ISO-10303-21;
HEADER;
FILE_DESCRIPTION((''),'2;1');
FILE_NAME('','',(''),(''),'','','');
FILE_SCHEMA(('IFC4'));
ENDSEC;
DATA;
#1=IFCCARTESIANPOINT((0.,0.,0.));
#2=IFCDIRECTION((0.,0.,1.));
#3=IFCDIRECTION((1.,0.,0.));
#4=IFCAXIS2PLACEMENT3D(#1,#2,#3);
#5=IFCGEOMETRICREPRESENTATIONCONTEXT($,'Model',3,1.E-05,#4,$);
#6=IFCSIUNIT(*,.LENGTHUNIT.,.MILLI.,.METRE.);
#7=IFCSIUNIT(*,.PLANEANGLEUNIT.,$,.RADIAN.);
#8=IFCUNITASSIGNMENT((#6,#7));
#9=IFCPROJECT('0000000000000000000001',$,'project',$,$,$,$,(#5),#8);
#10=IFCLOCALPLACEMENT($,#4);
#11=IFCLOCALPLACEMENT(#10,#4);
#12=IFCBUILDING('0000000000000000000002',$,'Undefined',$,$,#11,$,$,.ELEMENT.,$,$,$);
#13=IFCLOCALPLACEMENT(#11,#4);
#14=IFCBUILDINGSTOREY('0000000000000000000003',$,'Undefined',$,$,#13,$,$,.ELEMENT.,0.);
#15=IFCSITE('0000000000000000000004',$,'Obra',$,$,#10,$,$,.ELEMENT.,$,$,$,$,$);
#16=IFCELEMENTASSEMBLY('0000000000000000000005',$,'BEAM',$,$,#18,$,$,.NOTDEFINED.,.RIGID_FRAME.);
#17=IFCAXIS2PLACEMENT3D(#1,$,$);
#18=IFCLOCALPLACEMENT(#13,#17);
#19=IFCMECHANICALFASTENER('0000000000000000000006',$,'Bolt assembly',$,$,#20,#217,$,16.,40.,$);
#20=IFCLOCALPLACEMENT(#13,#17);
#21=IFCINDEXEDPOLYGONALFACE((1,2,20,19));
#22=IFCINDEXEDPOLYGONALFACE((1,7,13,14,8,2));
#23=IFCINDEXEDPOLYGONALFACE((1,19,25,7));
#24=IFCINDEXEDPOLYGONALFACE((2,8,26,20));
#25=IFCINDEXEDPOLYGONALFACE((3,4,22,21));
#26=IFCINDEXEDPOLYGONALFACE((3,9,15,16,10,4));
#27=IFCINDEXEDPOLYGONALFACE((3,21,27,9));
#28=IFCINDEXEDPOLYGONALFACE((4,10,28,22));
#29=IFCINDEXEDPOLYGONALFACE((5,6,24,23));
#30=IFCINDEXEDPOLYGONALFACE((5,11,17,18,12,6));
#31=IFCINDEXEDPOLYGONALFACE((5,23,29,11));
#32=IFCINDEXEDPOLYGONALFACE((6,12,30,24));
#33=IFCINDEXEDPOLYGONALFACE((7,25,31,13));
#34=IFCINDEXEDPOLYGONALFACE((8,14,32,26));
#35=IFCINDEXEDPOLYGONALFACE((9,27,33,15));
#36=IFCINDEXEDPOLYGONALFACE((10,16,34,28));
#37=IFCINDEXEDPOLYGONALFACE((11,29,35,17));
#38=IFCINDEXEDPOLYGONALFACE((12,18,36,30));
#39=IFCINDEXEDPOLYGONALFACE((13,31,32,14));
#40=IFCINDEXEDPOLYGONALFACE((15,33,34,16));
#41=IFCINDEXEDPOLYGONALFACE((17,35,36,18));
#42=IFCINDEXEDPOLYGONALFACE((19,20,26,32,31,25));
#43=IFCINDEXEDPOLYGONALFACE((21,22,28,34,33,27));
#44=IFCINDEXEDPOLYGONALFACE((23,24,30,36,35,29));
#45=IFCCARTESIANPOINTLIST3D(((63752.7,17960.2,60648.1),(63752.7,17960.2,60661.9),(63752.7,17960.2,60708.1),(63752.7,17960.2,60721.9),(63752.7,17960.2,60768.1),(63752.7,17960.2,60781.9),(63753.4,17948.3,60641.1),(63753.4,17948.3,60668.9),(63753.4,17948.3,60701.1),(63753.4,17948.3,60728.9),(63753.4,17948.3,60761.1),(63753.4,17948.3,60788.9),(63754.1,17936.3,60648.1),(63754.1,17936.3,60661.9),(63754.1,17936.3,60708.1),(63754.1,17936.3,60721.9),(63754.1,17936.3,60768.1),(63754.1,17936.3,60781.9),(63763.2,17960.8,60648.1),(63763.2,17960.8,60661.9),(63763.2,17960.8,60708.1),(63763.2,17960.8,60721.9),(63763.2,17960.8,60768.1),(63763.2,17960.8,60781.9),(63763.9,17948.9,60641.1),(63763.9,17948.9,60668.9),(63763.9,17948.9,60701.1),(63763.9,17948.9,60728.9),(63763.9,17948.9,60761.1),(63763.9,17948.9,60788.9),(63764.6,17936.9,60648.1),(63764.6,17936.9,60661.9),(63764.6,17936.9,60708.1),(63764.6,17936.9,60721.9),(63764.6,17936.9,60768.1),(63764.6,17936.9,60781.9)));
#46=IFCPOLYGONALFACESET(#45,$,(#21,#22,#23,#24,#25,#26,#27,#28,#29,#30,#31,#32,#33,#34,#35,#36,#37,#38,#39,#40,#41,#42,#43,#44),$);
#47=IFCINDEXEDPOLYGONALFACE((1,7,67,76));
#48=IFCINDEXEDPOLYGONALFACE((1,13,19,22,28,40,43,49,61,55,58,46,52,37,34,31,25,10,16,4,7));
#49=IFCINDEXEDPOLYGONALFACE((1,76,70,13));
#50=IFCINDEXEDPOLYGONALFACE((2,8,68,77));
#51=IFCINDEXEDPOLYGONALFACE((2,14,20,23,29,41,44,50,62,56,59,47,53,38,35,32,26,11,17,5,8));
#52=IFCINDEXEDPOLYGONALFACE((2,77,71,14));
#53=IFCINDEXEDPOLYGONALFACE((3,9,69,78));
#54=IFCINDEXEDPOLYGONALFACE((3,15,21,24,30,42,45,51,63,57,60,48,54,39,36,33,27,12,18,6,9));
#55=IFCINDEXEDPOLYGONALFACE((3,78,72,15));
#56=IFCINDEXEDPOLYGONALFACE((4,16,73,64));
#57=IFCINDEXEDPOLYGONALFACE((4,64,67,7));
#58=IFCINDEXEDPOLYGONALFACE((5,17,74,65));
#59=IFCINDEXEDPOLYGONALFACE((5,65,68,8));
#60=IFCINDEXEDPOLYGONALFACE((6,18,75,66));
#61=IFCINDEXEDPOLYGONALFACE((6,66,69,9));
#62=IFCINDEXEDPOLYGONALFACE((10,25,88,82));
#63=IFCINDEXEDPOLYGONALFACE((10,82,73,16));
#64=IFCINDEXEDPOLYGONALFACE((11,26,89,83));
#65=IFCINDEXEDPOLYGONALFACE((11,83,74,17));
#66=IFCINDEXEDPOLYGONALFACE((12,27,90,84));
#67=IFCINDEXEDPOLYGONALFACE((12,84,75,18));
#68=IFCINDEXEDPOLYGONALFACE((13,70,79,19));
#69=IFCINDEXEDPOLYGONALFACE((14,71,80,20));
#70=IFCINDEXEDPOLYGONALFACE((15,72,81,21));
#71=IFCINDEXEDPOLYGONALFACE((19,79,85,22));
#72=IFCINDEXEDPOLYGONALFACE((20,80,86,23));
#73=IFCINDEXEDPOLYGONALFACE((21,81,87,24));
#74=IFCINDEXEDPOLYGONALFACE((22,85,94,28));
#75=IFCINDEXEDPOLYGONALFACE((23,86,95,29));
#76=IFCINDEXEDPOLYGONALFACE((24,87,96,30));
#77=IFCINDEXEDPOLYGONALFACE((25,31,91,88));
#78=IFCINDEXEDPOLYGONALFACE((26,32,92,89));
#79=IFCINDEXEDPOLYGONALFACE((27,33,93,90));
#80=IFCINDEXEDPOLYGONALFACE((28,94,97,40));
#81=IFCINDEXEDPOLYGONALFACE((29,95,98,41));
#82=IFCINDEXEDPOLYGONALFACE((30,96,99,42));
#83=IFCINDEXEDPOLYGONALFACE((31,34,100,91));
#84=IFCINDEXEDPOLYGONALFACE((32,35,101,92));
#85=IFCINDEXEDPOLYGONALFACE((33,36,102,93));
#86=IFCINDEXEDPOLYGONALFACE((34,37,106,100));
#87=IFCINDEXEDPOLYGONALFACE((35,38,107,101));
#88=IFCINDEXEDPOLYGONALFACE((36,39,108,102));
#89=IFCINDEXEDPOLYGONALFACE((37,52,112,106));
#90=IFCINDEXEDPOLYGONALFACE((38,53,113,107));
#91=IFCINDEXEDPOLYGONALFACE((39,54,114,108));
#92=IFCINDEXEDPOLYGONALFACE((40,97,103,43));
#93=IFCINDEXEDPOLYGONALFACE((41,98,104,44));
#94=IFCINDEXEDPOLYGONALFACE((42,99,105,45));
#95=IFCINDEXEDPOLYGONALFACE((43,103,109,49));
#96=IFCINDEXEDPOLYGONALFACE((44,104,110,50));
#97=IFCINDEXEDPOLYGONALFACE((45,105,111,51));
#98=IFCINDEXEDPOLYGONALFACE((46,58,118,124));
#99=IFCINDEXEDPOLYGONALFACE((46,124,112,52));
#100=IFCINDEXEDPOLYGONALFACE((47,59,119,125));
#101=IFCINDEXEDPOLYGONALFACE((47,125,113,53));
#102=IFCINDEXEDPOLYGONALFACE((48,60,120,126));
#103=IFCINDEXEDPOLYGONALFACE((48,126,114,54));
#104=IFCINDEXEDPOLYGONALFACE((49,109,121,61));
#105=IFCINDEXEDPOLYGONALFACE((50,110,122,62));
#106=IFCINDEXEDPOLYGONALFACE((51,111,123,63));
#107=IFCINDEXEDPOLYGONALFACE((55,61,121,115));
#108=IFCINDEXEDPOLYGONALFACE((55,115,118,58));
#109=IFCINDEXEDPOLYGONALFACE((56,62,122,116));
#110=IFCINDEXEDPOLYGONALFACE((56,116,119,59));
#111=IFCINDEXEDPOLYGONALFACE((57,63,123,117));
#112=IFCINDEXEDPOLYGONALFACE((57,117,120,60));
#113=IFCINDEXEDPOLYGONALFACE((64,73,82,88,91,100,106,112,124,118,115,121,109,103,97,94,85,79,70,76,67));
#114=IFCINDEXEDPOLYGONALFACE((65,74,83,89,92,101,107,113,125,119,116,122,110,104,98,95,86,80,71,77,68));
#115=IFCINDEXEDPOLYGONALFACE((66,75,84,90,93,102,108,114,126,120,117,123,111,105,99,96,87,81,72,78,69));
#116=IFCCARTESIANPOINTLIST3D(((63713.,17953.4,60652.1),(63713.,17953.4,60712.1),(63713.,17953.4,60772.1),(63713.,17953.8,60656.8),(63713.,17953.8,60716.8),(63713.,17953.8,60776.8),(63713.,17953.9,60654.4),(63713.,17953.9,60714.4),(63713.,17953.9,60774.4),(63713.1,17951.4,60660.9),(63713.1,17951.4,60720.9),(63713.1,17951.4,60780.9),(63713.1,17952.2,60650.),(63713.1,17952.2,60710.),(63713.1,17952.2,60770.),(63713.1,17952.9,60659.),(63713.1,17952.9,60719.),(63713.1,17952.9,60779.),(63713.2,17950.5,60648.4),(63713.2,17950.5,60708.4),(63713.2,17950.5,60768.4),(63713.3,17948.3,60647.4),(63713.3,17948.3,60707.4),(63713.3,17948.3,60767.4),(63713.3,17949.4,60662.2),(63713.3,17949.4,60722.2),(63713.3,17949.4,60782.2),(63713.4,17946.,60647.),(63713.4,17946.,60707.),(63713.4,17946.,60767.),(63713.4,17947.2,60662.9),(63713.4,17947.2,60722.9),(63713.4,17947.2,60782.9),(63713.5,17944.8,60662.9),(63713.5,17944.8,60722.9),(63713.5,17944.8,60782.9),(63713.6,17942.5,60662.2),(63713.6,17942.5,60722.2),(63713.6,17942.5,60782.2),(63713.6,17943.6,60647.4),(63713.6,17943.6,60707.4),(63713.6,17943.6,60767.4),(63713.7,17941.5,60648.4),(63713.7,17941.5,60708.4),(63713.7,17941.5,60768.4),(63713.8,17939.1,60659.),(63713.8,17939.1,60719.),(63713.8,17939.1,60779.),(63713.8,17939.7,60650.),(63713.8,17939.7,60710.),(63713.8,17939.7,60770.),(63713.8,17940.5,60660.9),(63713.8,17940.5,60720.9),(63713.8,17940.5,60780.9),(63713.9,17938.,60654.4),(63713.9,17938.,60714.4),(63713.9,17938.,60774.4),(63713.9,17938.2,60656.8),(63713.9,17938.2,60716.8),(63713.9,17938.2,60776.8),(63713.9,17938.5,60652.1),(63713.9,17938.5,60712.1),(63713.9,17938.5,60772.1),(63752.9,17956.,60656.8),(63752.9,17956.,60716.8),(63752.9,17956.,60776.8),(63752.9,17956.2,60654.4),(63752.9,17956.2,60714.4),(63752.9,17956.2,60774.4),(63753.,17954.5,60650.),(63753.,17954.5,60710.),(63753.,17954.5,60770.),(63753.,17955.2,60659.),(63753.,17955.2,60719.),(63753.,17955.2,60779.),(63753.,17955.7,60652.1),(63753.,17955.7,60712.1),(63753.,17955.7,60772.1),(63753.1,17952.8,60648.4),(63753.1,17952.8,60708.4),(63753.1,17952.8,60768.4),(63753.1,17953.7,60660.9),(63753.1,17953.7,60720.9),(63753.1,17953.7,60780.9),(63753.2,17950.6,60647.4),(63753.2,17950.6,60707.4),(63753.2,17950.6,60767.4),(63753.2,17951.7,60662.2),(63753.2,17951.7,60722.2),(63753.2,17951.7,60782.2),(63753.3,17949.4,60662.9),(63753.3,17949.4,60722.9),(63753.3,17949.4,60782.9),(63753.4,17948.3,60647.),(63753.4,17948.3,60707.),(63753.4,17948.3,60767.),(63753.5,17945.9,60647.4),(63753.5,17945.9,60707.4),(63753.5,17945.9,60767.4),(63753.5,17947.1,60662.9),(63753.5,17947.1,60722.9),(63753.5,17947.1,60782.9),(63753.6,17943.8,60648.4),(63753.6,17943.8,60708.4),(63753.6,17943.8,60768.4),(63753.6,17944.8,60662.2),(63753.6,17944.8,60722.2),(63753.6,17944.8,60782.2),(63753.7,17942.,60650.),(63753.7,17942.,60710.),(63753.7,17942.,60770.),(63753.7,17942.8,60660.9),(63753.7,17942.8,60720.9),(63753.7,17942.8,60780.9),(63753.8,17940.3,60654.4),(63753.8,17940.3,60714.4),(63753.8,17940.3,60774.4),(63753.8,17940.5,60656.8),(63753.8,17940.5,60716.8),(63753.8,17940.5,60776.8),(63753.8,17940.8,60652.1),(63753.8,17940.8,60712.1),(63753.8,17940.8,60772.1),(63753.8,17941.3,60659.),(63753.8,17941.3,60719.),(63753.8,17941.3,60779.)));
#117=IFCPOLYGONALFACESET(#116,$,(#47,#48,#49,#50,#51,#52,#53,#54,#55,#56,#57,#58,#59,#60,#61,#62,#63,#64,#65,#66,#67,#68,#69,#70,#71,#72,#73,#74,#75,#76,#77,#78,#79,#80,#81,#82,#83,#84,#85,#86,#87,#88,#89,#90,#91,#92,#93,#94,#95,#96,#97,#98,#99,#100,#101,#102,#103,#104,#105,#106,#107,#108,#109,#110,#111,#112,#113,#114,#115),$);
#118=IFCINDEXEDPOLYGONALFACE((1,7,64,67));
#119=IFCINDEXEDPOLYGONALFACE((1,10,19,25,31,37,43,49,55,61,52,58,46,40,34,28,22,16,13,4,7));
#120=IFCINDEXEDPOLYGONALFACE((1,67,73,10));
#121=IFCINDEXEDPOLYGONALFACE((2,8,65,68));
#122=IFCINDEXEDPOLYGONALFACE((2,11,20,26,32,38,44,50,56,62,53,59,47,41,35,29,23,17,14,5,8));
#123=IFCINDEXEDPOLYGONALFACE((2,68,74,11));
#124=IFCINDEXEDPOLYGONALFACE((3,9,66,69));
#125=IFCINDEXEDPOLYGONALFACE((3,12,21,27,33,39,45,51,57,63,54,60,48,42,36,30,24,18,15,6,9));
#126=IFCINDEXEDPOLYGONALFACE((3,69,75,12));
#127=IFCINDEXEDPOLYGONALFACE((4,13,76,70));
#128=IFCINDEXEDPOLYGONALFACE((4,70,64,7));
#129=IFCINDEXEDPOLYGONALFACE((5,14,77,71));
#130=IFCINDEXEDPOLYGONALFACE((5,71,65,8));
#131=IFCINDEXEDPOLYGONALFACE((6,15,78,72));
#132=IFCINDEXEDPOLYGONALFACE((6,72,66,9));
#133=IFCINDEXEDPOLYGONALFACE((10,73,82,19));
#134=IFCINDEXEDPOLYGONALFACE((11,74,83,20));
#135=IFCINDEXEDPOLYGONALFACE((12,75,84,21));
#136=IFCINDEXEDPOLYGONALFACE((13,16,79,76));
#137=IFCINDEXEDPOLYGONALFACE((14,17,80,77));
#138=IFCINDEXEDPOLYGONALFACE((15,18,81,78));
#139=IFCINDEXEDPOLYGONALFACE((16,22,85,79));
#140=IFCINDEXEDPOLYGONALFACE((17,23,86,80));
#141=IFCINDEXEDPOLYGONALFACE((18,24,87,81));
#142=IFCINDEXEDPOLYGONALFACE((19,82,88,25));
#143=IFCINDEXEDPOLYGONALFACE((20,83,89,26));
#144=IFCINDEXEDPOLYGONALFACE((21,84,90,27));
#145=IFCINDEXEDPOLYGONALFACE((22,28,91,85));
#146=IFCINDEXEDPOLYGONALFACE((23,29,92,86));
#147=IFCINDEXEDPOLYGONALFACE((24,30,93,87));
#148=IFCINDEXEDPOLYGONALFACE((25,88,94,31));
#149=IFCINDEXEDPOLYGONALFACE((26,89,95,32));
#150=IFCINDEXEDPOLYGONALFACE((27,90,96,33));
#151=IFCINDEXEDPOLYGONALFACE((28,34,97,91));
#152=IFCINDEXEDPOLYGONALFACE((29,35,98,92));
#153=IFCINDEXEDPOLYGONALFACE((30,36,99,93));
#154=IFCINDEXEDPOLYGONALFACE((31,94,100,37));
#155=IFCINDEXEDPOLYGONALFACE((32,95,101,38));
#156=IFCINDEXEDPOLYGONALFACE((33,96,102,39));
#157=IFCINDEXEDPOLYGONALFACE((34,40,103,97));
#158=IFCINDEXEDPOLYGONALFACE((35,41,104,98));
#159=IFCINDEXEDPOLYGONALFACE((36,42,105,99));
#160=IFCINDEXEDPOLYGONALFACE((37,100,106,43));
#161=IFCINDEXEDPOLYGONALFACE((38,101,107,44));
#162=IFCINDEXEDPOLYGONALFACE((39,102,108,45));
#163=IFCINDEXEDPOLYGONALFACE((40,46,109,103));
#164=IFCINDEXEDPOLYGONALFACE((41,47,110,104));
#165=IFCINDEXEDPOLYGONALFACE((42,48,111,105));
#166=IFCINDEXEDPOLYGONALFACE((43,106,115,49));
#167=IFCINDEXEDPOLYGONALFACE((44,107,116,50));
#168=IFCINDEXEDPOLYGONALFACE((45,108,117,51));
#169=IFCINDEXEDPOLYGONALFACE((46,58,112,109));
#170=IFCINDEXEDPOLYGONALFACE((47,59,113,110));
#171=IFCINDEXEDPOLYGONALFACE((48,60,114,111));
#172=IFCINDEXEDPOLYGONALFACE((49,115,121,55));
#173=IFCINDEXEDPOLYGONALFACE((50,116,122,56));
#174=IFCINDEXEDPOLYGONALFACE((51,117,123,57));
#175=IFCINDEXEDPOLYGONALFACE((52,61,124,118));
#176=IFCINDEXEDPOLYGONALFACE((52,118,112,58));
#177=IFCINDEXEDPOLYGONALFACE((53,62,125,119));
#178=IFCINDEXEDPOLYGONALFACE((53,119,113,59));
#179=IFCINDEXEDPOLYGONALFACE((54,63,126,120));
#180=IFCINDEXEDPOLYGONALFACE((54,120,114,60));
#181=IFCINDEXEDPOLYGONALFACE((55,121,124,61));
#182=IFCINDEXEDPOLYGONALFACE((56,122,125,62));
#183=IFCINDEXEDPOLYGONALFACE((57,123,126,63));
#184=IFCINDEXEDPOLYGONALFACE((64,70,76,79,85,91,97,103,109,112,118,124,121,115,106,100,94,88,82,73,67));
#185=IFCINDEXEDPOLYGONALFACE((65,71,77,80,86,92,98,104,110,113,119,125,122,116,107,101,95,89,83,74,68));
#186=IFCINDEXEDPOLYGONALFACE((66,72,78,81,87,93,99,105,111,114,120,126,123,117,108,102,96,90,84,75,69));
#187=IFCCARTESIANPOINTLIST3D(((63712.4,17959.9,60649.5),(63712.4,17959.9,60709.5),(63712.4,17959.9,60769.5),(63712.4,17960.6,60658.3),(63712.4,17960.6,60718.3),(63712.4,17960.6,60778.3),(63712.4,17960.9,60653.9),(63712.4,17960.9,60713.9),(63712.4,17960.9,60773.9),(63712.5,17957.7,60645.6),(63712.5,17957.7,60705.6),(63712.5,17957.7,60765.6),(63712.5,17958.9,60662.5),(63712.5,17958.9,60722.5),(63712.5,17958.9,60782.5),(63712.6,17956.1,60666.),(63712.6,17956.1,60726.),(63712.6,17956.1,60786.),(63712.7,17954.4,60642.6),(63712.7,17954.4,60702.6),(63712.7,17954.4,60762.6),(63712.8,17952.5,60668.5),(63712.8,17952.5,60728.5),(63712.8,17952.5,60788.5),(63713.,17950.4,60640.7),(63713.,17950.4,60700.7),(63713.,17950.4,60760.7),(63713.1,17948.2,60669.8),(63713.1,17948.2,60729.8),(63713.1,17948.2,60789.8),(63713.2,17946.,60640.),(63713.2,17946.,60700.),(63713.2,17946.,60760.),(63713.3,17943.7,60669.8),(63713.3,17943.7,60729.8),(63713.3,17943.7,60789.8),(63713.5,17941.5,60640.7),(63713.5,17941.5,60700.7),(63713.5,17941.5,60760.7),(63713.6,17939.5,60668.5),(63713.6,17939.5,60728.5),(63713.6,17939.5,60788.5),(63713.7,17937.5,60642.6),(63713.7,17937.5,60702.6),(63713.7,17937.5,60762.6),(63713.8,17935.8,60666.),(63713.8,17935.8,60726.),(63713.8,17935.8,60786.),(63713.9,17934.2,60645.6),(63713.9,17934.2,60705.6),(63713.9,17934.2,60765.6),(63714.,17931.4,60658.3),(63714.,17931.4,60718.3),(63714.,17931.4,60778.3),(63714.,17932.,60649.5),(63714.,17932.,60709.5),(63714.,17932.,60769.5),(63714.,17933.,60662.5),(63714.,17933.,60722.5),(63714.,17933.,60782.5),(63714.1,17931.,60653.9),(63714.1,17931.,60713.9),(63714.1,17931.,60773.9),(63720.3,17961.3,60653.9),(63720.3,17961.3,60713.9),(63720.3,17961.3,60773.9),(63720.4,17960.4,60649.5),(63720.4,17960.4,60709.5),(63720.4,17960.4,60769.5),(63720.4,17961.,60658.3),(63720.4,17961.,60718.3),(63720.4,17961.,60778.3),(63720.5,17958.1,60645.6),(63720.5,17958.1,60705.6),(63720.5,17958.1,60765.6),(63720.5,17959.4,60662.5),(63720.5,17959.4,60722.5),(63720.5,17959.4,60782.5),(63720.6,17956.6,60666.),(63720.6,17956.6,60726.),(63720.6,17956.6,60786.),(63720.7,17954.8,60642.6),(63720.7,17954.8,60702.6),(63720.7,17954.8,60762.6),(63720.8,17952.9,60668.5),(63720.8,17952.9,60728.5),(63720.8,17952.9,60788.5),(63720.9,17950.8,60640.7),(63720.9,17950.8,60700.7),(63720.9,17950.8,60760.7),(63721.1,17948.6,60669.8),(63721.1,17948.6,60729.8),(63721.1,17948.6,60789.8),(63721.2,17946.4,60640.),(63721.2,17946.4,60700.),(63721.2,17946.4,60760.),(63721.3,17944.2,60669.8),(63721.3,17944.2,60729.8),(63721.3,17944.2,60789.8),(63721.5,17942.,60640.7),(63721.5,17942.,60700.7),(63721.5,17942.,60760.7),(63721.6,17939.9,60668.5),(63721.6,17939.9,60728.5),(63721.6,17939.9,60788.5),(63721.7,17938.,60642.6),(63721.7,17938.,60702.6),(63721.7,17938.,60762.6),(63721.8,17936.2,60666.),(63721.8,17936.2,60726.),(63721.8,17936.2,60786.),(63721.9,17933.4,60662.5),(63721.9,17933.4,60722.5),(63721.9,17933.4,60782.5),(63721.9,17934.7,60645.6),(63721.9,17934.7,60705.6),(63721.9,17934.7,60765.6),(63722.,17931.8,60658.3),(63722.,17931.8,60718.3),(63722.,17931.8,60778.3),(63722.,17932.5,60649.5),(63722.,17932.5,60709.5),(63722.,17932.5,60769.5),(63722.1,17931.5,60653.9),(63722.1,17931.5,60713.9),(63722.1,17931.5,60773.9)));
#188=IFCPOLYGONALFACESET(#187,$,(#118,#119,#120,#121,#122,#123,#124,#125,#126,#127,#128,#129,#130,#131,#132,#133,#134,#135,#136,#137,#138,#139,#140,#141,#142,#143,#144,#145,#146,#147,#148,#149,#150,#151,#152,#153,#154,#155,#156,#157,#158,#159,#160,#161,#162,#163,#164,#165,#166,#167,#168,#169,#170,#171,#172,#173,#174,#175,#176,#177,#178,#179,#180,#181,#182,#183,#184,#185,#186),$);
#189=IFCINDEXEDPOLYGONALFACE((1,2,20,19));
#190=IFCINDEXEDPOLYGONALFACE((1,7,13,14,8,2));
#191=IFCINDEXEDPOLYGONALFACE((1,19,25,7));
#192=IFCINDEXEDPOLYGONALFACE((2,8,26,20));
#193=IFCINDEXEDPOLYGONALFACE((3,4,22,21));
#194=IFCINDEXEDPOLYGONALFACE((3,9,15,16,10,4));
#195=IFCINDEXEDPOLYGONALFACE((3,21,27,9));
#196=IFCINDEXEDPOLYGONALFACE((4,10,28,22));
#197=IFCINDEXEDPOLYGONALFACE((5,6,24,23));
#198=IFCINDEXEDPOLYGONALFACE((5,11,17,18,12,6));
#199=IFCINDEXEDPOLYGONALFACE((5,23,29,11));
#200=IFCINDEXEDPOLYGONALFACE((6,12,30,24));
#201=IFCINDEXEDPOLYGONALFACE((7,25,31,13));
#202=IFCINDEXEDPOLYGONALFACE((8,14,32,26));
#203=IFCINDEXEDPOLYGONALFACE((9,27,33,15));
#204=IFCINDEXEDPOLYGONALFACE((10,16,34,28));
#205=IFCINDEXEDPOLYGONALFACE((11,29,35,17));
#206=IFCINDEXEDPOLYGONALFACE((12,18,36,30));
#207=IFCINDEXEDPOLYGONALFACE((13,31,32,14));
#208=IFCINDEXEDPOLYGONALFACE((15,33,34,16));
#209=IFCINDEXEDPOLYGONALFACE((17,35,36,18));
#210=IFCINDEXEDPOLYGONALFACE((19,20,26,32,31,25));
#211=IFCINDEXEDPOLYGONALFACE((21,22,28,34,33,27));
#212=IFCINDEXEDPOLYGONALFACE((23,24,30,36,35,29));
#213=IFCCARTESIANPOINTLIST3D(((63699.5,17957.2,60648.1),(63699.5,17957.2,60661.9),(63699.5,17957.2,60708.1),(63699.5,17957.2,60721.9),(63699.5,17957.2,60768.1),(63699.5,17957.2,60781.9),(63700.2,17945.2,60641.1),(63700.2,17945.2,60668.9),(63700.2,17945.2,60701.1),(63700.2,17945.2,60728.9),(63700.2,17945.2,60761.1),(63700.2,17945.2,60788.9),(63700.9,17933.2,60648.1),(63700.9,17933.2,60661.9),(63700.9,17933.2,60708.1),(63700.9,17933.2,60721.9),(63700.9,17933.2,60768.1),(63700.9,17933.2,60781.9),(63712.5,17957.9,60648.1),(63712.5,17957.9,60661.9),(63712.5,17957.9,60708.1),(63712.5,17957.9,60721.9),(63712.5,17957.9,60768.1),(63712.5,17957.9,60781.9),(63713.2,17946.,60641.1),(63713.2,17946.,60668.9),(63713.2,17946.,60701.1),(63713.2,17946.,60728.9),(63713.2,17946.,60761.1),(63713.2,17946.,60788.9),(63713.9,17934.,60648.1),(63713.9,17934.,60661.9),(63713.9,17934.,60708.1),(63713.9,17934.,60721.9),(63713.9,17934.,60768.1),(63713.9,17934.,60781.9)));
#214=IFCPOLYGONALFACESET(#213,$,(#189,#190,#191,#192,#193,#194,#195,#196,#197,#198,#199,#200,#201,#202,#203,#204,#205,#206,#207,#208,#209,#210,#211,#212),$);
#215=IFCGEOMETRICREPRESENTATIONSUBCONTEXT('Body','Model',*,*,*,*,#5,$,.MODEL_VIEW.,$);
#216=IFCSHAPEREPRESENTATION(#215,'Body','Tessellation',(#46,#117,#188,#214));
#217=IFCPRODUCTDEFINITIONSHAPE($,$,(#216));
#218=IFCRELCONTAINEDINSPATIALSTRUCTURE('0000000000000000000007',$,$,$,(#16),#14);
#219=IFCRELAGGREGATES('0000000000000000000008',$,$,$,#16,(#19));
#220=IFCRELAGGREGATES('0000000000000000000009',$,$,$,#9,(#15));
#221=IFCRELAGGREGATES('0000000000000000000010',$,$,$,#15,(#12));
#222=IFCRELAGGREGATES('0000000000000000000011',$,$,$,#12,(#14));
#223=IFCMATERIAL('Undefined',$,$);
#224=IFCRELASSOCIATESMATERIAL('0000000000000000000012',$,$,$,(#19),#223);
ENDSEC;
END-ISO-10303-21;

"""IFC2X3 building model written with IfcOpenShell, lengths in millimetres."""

from ifc_helpers import new_model, si_unit, frame, origin_with_axes, origin_2d_with_axis, place, context, subcontext, project, spatial, polyline, circle, outline, extrude, source, transform, mapped, material, element, aggregate, save


model = new_model("IFC2X3")

# Units and contexts
model_context = context("Model", 3, precision=1e-05, world=origin_with_axes())
body_context = subcontext(model_context, "Body", "Model", "MODEL_VIEW")
ifc_project = project(units=[si_unit("LENGTHUNIT", "METRE", prefix="MILLI"), si_unit("PLANEANGLEUNIT", "RADIAN")], contexts=[model_context])

# Site, building, storey
site_placement = place(None, origin_with_axes())
site = spatial("IfcSite", under=ifc_project, at=site_placement, Name="Obra", CompositionType="ELEMENT")
building_placement = place(site_placement, origin_with_axes())
building = spatial("IfcBuilding", under=site, at=building_placement, Name="Undefined", CompositionType="ELEMENT")
storey_placement = place(building_placement, origin_with_axes())
storey = spatial("IfcBuildingStorey", under=building, at=storey_placement, Name="Undefined", CompositionType="ELEMENT", Elevation=0.0)

# Element assembly, mechanical fastener
ifc_material_1 = material(Name="Undefined")
assembly_1_placement = place(storey_placement, origin_with_axes())
assembly_1 = element("IfcElementAssembly", 1, at=assembly_1_placement, inside=storey, Name="BEAM", AssemblyPlace="NOTDEFINED", PredefinedType="RIGID_FRAME")
shared_shape_1 = source(origin_with_axes(), body_context, "Body", "SweptSolid", [
    extrude(outline(polyline([(13.9, 0.0), (6.9, 12.0), (-6.9, 12.0), (-13.9, 0.0), (-6.9, -12.0), (6.9, -12.0), (13.9, 0.0)])), frame((0.0, -45.9, 0.0), z_axis=(0.0, 1.0, 0.0), x_axis=(1.0, 0.0, 0.0)), (0.0, 0.0, 1.0), 10.6),
    extrude(circle(Radius=8.0, at=origin_2d_with_axis()), frame((0.0, -35.3, 0.0), z_axis=(0.0, 1.0, 0.0), x_axis=(1.0, 0.0, 0.0)), (0.0, 0.0, 1.0), 40.0),
    extrude(circle(Radius=15.0, at=origin_2d_with_axis()), frame((0.0, -3.1, 0.0), z_axis=(0.0, 1.0, 0.0), x_axis=(1.0, 0.0, 0.0)), (0.0, 0.0, 1.0), 8.0),
    extrude(outline(polyline([(13.9, 0.0), (6.9, 12.0), (-6.9, 12.0), (-13.9, 0.0), (-6.9, -12.0), (6.9, -12.0), (13.9, 0.0)])), frame((0.0, 4.9, 0.0), z_axis=(0.0, 1.0, 0.0), x_axis=(1.0, 0.0, 0.0)), (0.0, 0.0, 1.0), 13.0),
])
mechanical_fastener_1_placement = place(assembly_1_placement, frame((63721.0, 17896.3, 60835.0), z_axis=(-0.057107, 0.998368, 0.0), x_axis=(0.0, 0.0, -1.0)))
mechanical_fastener_1 = element("IfcMechanicalFastener", 2, at=mechanical_fastener_1_placement, material=ifc_material_1, Name="Bolt assembly", NominalDiameter=16.0, NominalLength=40.0, context=body_context, shape_type="MappedRepresentation", body=[
    mapped(shared_shape_1, transform((60.0, 0.0, 50.0))),
    mapped(shared_shape_1, transform((120.0, 0.0, 50.0))),
    mapped(shared_shape_1, transform((180.0, 0.0, 50.0))),
])
aggregate(assembly_1, [mechanical_fastener_1])

save(model, "model.ifc")
